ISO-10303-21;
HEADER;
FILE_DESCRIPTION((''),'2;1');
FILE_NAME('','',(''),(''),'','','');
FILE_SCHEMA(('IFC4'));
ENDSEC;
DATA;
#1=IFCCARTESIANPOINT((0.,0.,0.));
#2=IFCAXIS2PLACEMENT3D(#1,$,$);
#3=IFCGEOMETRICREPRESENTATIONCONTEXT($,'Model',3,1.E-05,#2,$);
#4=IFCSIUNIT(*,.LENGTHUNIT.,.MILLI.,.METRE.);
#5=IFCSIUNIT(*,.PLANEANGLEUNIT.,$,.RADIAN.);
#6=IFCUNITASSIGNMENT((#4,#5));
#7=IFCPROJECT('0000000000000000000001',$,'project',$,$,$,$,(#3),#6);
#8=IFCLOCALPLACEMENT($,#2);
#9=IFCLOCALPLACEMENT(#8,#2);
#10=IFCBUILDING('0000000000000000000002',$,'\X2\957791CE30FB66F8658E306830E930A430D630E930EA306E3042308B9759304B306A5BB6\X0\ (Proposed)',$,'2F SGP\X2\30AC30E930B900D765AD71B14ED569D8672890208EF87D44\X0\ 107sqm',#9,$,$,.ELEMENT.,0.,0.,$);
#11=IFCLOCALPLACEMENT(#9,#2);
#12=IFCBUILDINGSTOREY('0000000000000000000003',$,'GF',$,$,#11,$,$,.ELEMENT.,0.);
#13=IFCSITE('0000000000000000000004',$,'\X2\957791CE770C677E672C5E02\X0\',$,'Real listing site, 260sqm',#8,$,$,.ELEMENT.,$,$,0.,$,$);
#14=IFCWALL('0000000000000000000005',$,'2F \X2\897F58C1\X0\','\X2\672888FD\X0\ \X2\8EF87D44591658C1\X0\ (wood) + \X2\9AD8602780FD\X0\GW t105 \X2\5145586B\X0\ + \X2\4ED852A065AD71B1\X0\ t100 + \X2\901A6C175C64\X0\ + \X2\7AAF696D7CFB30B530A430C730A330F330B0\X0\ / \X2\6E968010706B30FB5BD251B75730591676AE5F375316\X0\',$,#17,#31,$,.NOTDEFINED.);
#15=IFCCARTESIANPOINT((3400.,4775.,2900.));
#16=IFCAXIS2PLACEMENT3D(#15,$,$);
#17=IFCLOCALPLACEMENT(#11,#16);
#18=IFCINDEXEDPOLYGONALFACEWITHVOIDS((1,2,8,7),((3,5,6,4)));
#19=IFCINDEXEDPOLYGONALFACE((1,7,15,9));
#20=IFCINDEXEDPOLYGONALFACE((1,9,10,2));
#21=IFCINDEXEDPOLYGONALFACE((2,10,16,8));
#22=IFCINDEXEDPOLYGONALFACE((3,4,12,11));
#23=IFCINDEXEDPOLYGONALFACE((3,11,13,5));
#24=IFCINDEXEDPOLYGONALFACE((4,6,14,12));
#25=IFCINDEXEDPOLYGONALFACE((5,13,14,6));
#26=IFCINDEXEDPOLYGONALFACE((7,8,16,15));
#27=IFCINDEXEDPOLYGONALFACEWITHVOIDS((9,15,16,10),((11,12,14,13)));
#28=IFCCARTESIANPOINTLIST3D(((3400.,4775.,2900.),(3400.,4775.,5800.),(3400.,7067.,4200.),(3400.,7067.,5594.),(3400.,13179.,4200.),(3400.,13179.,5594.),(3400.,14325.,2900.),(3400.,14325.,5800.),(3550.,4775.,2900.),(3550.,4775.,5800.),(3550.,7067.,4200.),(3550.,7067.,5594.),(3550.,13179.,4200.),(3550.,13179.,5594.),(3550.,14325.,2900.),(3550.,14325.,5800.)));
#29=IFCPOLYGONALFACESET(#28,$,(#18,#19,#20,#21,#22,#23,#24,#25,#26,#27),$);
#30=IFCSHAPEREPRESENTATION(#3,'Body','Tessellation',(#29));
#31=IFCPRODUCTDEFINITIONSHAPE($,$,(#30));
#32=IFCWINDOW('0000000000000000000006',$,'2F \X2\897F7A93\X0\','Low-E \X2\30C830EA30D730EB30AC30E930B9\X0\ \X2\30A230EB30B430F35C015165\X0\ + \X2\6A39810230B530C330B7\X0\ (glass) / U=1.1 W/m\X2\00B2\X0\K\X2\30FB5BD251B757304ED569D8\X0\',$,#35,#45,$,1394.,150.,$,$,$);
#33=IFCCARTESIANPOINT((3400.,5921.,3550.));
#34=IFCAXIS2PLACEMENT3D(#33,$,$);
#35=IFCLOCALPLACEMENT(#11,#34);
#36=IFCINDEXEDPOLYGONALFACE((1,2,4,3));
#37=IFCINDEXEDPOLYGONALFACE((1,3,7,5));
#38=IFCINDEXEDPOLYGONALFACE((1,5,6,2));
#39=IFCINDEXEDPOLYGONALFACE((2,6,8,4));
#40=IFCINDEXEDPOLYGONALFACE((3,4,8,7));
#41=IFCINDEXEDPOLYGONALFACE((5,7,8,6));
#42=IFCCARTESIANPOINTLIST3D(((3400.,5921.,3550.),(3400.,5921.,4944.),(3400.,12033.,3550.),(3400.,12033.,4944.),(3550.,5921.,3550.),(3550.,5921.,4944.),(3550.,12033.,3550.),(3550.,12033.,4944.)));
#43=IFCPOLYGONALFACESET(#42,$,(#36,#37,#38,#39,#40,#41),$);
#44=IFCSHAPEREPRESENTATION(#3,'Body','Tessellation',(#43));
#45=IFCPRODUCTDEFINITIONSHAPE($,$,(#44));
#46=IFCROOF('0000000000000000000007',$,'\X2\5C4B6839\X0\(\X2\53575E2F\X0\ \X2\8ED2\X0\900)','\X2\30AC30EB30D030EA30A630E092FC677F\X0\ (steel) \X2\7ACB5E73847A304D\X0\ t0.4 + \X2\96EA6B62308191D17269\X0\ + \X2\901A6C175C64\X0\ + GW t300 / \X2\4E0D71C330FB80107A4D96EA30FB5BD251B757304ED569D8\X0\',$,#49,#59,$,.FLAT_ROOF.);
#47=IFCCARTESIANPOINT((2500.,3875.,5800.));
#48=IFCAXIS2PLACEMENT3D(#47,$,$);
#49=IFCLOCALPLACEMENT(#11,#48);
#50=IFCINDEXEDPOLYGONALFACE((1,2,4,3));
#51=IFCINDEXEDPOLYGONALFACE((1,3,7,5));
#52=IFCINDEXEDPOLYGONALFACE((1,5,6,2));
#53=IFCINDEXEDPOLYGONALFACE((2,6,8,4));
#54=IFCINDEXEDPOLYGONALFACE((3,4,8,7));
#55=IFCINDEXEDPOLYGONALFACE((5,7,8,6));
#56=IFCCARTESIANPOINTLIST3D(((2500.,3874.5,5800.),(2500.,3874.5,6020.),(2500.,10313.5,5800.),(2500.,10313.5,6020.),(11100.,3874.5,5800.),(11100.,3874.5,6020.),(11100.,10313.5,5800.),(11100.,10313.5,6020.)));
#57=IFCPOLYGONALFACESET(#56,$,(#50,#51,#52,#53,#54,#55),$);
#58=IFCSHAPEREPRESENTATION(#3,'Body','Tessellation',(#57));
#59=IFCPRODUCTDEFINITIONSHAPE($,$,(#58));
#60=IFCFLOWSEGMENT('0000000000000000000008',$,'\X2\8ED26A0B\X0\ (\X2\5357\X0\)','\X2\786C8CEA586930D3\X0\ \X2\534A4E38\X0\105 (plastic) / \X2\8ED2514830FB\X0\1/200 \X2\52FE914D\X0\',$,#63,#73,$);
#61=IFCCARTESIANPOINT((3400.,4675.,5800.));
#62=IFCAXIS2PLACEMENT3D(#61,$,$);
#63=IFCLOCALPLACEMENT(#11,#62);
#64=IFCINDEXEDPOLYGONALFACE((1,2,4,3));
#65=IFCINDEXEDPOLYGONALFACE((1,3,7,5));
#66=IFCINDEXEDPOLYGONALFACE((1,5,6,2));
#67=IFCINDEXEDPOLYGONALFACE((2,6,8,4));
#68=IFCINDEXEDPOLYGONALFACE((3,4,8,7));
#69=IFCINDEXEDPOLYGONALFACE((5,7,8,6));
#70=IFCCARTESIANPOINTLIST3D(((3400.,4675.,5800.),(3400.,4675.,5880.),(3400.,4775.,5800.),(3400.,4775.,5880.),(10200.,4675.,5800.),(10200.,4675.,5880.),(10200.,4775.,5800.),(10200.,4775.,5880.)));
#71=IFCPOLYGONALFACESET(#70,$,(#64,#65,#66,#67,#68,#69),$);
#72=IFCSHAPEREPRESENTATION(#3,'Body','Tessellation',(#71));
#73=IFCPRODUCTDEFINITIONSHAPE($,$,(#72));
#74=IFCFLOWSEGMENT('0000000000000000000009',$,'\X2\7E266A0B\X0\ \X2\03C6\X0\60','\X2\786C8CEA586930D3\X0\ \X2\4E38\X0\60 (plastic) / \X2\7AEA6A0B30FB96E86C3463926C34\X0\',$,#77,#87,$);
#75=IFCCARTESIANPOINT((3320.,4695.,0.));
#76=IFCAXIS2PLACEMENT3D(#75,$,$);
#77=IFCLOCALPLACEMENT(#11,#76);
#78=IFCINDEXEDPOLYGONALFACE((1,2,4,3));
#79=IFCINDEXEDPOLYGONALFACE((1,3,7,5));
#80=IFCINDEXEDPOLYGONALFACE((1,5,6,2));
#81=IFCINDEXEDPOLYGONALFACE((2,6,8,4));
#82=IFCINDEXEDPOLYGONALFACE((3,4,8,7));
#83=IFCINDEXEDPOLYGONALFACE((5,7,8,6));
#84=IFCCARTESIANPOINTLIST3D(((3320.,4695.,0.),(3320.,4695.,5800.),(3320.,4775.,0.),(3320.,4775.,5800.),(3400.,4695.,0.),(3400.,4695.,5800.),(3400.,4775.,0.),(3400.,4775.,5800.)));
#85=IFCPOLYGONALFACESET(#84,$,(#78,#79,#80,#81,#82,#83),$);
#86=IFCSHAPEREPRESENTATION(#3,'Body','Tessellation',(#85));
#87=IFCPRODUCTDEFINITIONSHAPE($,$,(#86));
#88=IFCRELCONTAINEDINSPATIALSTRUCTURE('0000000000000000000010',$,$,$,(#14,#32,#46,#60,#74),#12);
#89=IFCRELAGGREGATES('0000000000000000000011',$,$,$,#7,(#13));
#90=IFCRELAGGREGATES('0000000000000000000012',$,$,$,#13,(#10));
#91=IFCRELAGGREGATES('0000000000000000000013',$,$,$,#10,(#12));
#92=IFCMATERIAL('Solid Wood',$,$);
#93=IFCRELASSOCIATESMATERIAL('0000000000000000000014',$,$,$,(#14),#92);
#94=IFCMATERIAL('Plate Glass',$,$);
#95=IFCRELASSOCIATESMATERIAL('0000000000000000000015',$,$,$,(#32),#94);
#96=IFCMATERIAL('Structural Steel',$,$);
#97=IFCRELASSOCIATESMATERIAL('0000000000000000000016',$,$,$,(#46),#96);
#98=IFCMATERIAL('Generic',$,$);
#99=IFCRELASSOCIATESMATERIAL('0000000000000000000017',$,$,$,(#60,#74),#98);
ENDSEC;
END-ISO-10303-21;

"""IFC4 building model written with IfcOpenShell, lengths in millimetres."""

from ifc_helpers import new_model, si_unit, frame, frame_2d, origin, place, context, project, spatial, rectangle, extrude, material, element, fill, save


model = new_model("IFC4")

# Units and contexts
model_context = context("Model", 3, precision=1e-05, world=origin())
ifc_project = project(units=[si_unit("LENGTHUNIT", "METRE", prefix="MILLI"), si_unit("PLANEANGLEUNIT", "RADIAN")], contexts=[model_context])

# Site, building, storey
site_placement = place(None, origin())
site = spatial("IfcSite", under=ifc_project, at=site_placement, Name="長野県松本市", ObjectType="Real listing site, 260sqm", CompositionType="ELEMENT", RefElevation=0.0)
building_placement = place(site_placement, origin())
building = spatial("IfcBuilding", under=site, at=building_placement, Name="長野・書斎とライブラリのある静かな家 (Proposed)", ObjectType="2F SGPガラス×断熱仕様木造軸組 107sqm", CompositionType="ELEMENT", ElevationOfRefHeight=0.0, ElevationOfTerrain=0.0)
storey_placement = place(building_placement, origin())
storey = spatial("IfcBuildingStorey", under=building, at=storey_placement, Name="GF", CompositionType="ELEMENT", Elevation=0.0)

# Shared definitions
ifc_material_1 = material(Name="Solid Wood")

# Shared definitions
ifc_material_2 = material(Name="Plate Glass")

# Wall, opening, window
wall_1_placement = place(storey_placement, frame((3400.0, 4775.0, 2900.0)))
wall_1 = element("IfcWall", 1, at=wall_1_placement, inside=storey, material=ifc_material_1, Name="2F 西壁", Description="木製 軸組外壁 (wood) + 高性能GW t105 充填 + 付加断熱 t100 + 通気層 + 窯業系サイディング / 準耐火・寒冷地外皮強化", PredefinedType="NOTDEFINED", context=model_context, shape_type="SweptSolid", body=[
    extrude(rectangle(XDim=150.0, YDim=9550.0, at=frame_2d((75.0, 4775.0))), frame((3400.0, 4775.0, 2900.0)), (0.0, 0.0, 1.0), 2900.0),
])
opening_1_placement = place(storey_placement, frame((3400.0, 5921.0, 3550.0)))
opening_1 = element("IfcOpeningElement", 2, at=opening_1_placement, cuts=wall_1, PredefinedType="NOTDEFINED", context=model_context, shape_type="SweptSolid", body=[
    extrude(rectangle(XDim=150.0, YDim=6112.0, at=frame_2d((75.0, 3056.0))), frame((3400.0, 5921.0, 3550.0)), (0.0, 0.0, 1.0), 1394.0),
])
window_1_placement = place(storey_placement, frame((3400.0, 5921.0, 3550.0)))
window_1 = element("IfcWindow", 3, at=window_1_placement, inside=storey, material=ifc_material_2, Name="2F 西窓", Description="Low-E トリプルガラス アルゴン封入 + 樹脂サッシ (glass) / U=1.1 W/m²K・寒冷地仕様", OverallHeight=1394.0, OverallWidth=150.0, context=model_context, shape_type="SweptSolid", body=[
    extrude(rectangle(XDim=150.0, YDim=6112.0, at=frame_2d((75.0, 3056.0))), frame((3400.0, 5921.0, 3550.0)), (0.0, 0.0, 1.0), 1394.0),
])
fill(opening_1, window_1)

# Roof
ifc_material_3 = material(Name="Structural Steel")
for number, where, name in (
    (4, (2500.0, 3875.0, 5800.0), "屋根(南帯 軒900)"),
):
    element("IfcRoof", number, at=place(storey_placement, frame(where)), inside=storey, material=ifc_material_3, Name=name, Description="ガルバリウム鋼板 (steel) 立平葺き t0.4 + 雪止め金物 + 通気層 + GW t300 / 不燃・耐積雪・寒冷地仕様", PredefinedType="FLAT_ROOF", context=model_context, shape_type="SweptSolid", body=[
        extrude(rectangle(XDim=8600.0, YDim=6439.0, at=frame_2d((4300.0, 3219.0))), frame((2500.0, 3875.0, 5800.0)), (0.0, 0.0, 1.0), 220.0),
    ])

# Flow segments
ifc_material_4 = material(Name="Generic")
flow_segment_1_placement = place(storey_placement, frame((3400.0, 4675.0, 5800.0)))
element("IfcFlowSegment", 5, at=flow_segment_1_placement, inside=storey, material=ifc_material_4, Name="軒樋 (南)", Description="硬質塩ビ 半丸105 (plastic) / 軒先・1/200 勾配", context=model_context, shape_type="SweptSolid", body=[
    extrude(rectangle(XDim=6800.0, YDim=100.0, at=frame_2d((3400.0, 50.0))), frame((3400.0, 4675.0, 5800.0)), (0.0, 0.0, 1.0), 80.0),
])
flow_segment_2_placement = place(storey_placement, frame((3320.0, 4695.0, 0.0)))
element("IfcFlowSegment", 6, at=flow_segment_2_placement, inside=storey, material=ifc_material_4, Name="縦樋 φ60", Description="硬質塩ビ 丸60 (plastic) / 竪樋・雨水排水", context=model_context, shape_type="SweptSolid", body=[
    extrude(rectangle(XDim=80.0, YDim=80.0, at=frame_2d((40.0, 40.0))), frame((3320.0, 4695.0, 0.0)), (0.0, 0.0, 1.0), 5800.0),
])

save(model, "model.ifc")
